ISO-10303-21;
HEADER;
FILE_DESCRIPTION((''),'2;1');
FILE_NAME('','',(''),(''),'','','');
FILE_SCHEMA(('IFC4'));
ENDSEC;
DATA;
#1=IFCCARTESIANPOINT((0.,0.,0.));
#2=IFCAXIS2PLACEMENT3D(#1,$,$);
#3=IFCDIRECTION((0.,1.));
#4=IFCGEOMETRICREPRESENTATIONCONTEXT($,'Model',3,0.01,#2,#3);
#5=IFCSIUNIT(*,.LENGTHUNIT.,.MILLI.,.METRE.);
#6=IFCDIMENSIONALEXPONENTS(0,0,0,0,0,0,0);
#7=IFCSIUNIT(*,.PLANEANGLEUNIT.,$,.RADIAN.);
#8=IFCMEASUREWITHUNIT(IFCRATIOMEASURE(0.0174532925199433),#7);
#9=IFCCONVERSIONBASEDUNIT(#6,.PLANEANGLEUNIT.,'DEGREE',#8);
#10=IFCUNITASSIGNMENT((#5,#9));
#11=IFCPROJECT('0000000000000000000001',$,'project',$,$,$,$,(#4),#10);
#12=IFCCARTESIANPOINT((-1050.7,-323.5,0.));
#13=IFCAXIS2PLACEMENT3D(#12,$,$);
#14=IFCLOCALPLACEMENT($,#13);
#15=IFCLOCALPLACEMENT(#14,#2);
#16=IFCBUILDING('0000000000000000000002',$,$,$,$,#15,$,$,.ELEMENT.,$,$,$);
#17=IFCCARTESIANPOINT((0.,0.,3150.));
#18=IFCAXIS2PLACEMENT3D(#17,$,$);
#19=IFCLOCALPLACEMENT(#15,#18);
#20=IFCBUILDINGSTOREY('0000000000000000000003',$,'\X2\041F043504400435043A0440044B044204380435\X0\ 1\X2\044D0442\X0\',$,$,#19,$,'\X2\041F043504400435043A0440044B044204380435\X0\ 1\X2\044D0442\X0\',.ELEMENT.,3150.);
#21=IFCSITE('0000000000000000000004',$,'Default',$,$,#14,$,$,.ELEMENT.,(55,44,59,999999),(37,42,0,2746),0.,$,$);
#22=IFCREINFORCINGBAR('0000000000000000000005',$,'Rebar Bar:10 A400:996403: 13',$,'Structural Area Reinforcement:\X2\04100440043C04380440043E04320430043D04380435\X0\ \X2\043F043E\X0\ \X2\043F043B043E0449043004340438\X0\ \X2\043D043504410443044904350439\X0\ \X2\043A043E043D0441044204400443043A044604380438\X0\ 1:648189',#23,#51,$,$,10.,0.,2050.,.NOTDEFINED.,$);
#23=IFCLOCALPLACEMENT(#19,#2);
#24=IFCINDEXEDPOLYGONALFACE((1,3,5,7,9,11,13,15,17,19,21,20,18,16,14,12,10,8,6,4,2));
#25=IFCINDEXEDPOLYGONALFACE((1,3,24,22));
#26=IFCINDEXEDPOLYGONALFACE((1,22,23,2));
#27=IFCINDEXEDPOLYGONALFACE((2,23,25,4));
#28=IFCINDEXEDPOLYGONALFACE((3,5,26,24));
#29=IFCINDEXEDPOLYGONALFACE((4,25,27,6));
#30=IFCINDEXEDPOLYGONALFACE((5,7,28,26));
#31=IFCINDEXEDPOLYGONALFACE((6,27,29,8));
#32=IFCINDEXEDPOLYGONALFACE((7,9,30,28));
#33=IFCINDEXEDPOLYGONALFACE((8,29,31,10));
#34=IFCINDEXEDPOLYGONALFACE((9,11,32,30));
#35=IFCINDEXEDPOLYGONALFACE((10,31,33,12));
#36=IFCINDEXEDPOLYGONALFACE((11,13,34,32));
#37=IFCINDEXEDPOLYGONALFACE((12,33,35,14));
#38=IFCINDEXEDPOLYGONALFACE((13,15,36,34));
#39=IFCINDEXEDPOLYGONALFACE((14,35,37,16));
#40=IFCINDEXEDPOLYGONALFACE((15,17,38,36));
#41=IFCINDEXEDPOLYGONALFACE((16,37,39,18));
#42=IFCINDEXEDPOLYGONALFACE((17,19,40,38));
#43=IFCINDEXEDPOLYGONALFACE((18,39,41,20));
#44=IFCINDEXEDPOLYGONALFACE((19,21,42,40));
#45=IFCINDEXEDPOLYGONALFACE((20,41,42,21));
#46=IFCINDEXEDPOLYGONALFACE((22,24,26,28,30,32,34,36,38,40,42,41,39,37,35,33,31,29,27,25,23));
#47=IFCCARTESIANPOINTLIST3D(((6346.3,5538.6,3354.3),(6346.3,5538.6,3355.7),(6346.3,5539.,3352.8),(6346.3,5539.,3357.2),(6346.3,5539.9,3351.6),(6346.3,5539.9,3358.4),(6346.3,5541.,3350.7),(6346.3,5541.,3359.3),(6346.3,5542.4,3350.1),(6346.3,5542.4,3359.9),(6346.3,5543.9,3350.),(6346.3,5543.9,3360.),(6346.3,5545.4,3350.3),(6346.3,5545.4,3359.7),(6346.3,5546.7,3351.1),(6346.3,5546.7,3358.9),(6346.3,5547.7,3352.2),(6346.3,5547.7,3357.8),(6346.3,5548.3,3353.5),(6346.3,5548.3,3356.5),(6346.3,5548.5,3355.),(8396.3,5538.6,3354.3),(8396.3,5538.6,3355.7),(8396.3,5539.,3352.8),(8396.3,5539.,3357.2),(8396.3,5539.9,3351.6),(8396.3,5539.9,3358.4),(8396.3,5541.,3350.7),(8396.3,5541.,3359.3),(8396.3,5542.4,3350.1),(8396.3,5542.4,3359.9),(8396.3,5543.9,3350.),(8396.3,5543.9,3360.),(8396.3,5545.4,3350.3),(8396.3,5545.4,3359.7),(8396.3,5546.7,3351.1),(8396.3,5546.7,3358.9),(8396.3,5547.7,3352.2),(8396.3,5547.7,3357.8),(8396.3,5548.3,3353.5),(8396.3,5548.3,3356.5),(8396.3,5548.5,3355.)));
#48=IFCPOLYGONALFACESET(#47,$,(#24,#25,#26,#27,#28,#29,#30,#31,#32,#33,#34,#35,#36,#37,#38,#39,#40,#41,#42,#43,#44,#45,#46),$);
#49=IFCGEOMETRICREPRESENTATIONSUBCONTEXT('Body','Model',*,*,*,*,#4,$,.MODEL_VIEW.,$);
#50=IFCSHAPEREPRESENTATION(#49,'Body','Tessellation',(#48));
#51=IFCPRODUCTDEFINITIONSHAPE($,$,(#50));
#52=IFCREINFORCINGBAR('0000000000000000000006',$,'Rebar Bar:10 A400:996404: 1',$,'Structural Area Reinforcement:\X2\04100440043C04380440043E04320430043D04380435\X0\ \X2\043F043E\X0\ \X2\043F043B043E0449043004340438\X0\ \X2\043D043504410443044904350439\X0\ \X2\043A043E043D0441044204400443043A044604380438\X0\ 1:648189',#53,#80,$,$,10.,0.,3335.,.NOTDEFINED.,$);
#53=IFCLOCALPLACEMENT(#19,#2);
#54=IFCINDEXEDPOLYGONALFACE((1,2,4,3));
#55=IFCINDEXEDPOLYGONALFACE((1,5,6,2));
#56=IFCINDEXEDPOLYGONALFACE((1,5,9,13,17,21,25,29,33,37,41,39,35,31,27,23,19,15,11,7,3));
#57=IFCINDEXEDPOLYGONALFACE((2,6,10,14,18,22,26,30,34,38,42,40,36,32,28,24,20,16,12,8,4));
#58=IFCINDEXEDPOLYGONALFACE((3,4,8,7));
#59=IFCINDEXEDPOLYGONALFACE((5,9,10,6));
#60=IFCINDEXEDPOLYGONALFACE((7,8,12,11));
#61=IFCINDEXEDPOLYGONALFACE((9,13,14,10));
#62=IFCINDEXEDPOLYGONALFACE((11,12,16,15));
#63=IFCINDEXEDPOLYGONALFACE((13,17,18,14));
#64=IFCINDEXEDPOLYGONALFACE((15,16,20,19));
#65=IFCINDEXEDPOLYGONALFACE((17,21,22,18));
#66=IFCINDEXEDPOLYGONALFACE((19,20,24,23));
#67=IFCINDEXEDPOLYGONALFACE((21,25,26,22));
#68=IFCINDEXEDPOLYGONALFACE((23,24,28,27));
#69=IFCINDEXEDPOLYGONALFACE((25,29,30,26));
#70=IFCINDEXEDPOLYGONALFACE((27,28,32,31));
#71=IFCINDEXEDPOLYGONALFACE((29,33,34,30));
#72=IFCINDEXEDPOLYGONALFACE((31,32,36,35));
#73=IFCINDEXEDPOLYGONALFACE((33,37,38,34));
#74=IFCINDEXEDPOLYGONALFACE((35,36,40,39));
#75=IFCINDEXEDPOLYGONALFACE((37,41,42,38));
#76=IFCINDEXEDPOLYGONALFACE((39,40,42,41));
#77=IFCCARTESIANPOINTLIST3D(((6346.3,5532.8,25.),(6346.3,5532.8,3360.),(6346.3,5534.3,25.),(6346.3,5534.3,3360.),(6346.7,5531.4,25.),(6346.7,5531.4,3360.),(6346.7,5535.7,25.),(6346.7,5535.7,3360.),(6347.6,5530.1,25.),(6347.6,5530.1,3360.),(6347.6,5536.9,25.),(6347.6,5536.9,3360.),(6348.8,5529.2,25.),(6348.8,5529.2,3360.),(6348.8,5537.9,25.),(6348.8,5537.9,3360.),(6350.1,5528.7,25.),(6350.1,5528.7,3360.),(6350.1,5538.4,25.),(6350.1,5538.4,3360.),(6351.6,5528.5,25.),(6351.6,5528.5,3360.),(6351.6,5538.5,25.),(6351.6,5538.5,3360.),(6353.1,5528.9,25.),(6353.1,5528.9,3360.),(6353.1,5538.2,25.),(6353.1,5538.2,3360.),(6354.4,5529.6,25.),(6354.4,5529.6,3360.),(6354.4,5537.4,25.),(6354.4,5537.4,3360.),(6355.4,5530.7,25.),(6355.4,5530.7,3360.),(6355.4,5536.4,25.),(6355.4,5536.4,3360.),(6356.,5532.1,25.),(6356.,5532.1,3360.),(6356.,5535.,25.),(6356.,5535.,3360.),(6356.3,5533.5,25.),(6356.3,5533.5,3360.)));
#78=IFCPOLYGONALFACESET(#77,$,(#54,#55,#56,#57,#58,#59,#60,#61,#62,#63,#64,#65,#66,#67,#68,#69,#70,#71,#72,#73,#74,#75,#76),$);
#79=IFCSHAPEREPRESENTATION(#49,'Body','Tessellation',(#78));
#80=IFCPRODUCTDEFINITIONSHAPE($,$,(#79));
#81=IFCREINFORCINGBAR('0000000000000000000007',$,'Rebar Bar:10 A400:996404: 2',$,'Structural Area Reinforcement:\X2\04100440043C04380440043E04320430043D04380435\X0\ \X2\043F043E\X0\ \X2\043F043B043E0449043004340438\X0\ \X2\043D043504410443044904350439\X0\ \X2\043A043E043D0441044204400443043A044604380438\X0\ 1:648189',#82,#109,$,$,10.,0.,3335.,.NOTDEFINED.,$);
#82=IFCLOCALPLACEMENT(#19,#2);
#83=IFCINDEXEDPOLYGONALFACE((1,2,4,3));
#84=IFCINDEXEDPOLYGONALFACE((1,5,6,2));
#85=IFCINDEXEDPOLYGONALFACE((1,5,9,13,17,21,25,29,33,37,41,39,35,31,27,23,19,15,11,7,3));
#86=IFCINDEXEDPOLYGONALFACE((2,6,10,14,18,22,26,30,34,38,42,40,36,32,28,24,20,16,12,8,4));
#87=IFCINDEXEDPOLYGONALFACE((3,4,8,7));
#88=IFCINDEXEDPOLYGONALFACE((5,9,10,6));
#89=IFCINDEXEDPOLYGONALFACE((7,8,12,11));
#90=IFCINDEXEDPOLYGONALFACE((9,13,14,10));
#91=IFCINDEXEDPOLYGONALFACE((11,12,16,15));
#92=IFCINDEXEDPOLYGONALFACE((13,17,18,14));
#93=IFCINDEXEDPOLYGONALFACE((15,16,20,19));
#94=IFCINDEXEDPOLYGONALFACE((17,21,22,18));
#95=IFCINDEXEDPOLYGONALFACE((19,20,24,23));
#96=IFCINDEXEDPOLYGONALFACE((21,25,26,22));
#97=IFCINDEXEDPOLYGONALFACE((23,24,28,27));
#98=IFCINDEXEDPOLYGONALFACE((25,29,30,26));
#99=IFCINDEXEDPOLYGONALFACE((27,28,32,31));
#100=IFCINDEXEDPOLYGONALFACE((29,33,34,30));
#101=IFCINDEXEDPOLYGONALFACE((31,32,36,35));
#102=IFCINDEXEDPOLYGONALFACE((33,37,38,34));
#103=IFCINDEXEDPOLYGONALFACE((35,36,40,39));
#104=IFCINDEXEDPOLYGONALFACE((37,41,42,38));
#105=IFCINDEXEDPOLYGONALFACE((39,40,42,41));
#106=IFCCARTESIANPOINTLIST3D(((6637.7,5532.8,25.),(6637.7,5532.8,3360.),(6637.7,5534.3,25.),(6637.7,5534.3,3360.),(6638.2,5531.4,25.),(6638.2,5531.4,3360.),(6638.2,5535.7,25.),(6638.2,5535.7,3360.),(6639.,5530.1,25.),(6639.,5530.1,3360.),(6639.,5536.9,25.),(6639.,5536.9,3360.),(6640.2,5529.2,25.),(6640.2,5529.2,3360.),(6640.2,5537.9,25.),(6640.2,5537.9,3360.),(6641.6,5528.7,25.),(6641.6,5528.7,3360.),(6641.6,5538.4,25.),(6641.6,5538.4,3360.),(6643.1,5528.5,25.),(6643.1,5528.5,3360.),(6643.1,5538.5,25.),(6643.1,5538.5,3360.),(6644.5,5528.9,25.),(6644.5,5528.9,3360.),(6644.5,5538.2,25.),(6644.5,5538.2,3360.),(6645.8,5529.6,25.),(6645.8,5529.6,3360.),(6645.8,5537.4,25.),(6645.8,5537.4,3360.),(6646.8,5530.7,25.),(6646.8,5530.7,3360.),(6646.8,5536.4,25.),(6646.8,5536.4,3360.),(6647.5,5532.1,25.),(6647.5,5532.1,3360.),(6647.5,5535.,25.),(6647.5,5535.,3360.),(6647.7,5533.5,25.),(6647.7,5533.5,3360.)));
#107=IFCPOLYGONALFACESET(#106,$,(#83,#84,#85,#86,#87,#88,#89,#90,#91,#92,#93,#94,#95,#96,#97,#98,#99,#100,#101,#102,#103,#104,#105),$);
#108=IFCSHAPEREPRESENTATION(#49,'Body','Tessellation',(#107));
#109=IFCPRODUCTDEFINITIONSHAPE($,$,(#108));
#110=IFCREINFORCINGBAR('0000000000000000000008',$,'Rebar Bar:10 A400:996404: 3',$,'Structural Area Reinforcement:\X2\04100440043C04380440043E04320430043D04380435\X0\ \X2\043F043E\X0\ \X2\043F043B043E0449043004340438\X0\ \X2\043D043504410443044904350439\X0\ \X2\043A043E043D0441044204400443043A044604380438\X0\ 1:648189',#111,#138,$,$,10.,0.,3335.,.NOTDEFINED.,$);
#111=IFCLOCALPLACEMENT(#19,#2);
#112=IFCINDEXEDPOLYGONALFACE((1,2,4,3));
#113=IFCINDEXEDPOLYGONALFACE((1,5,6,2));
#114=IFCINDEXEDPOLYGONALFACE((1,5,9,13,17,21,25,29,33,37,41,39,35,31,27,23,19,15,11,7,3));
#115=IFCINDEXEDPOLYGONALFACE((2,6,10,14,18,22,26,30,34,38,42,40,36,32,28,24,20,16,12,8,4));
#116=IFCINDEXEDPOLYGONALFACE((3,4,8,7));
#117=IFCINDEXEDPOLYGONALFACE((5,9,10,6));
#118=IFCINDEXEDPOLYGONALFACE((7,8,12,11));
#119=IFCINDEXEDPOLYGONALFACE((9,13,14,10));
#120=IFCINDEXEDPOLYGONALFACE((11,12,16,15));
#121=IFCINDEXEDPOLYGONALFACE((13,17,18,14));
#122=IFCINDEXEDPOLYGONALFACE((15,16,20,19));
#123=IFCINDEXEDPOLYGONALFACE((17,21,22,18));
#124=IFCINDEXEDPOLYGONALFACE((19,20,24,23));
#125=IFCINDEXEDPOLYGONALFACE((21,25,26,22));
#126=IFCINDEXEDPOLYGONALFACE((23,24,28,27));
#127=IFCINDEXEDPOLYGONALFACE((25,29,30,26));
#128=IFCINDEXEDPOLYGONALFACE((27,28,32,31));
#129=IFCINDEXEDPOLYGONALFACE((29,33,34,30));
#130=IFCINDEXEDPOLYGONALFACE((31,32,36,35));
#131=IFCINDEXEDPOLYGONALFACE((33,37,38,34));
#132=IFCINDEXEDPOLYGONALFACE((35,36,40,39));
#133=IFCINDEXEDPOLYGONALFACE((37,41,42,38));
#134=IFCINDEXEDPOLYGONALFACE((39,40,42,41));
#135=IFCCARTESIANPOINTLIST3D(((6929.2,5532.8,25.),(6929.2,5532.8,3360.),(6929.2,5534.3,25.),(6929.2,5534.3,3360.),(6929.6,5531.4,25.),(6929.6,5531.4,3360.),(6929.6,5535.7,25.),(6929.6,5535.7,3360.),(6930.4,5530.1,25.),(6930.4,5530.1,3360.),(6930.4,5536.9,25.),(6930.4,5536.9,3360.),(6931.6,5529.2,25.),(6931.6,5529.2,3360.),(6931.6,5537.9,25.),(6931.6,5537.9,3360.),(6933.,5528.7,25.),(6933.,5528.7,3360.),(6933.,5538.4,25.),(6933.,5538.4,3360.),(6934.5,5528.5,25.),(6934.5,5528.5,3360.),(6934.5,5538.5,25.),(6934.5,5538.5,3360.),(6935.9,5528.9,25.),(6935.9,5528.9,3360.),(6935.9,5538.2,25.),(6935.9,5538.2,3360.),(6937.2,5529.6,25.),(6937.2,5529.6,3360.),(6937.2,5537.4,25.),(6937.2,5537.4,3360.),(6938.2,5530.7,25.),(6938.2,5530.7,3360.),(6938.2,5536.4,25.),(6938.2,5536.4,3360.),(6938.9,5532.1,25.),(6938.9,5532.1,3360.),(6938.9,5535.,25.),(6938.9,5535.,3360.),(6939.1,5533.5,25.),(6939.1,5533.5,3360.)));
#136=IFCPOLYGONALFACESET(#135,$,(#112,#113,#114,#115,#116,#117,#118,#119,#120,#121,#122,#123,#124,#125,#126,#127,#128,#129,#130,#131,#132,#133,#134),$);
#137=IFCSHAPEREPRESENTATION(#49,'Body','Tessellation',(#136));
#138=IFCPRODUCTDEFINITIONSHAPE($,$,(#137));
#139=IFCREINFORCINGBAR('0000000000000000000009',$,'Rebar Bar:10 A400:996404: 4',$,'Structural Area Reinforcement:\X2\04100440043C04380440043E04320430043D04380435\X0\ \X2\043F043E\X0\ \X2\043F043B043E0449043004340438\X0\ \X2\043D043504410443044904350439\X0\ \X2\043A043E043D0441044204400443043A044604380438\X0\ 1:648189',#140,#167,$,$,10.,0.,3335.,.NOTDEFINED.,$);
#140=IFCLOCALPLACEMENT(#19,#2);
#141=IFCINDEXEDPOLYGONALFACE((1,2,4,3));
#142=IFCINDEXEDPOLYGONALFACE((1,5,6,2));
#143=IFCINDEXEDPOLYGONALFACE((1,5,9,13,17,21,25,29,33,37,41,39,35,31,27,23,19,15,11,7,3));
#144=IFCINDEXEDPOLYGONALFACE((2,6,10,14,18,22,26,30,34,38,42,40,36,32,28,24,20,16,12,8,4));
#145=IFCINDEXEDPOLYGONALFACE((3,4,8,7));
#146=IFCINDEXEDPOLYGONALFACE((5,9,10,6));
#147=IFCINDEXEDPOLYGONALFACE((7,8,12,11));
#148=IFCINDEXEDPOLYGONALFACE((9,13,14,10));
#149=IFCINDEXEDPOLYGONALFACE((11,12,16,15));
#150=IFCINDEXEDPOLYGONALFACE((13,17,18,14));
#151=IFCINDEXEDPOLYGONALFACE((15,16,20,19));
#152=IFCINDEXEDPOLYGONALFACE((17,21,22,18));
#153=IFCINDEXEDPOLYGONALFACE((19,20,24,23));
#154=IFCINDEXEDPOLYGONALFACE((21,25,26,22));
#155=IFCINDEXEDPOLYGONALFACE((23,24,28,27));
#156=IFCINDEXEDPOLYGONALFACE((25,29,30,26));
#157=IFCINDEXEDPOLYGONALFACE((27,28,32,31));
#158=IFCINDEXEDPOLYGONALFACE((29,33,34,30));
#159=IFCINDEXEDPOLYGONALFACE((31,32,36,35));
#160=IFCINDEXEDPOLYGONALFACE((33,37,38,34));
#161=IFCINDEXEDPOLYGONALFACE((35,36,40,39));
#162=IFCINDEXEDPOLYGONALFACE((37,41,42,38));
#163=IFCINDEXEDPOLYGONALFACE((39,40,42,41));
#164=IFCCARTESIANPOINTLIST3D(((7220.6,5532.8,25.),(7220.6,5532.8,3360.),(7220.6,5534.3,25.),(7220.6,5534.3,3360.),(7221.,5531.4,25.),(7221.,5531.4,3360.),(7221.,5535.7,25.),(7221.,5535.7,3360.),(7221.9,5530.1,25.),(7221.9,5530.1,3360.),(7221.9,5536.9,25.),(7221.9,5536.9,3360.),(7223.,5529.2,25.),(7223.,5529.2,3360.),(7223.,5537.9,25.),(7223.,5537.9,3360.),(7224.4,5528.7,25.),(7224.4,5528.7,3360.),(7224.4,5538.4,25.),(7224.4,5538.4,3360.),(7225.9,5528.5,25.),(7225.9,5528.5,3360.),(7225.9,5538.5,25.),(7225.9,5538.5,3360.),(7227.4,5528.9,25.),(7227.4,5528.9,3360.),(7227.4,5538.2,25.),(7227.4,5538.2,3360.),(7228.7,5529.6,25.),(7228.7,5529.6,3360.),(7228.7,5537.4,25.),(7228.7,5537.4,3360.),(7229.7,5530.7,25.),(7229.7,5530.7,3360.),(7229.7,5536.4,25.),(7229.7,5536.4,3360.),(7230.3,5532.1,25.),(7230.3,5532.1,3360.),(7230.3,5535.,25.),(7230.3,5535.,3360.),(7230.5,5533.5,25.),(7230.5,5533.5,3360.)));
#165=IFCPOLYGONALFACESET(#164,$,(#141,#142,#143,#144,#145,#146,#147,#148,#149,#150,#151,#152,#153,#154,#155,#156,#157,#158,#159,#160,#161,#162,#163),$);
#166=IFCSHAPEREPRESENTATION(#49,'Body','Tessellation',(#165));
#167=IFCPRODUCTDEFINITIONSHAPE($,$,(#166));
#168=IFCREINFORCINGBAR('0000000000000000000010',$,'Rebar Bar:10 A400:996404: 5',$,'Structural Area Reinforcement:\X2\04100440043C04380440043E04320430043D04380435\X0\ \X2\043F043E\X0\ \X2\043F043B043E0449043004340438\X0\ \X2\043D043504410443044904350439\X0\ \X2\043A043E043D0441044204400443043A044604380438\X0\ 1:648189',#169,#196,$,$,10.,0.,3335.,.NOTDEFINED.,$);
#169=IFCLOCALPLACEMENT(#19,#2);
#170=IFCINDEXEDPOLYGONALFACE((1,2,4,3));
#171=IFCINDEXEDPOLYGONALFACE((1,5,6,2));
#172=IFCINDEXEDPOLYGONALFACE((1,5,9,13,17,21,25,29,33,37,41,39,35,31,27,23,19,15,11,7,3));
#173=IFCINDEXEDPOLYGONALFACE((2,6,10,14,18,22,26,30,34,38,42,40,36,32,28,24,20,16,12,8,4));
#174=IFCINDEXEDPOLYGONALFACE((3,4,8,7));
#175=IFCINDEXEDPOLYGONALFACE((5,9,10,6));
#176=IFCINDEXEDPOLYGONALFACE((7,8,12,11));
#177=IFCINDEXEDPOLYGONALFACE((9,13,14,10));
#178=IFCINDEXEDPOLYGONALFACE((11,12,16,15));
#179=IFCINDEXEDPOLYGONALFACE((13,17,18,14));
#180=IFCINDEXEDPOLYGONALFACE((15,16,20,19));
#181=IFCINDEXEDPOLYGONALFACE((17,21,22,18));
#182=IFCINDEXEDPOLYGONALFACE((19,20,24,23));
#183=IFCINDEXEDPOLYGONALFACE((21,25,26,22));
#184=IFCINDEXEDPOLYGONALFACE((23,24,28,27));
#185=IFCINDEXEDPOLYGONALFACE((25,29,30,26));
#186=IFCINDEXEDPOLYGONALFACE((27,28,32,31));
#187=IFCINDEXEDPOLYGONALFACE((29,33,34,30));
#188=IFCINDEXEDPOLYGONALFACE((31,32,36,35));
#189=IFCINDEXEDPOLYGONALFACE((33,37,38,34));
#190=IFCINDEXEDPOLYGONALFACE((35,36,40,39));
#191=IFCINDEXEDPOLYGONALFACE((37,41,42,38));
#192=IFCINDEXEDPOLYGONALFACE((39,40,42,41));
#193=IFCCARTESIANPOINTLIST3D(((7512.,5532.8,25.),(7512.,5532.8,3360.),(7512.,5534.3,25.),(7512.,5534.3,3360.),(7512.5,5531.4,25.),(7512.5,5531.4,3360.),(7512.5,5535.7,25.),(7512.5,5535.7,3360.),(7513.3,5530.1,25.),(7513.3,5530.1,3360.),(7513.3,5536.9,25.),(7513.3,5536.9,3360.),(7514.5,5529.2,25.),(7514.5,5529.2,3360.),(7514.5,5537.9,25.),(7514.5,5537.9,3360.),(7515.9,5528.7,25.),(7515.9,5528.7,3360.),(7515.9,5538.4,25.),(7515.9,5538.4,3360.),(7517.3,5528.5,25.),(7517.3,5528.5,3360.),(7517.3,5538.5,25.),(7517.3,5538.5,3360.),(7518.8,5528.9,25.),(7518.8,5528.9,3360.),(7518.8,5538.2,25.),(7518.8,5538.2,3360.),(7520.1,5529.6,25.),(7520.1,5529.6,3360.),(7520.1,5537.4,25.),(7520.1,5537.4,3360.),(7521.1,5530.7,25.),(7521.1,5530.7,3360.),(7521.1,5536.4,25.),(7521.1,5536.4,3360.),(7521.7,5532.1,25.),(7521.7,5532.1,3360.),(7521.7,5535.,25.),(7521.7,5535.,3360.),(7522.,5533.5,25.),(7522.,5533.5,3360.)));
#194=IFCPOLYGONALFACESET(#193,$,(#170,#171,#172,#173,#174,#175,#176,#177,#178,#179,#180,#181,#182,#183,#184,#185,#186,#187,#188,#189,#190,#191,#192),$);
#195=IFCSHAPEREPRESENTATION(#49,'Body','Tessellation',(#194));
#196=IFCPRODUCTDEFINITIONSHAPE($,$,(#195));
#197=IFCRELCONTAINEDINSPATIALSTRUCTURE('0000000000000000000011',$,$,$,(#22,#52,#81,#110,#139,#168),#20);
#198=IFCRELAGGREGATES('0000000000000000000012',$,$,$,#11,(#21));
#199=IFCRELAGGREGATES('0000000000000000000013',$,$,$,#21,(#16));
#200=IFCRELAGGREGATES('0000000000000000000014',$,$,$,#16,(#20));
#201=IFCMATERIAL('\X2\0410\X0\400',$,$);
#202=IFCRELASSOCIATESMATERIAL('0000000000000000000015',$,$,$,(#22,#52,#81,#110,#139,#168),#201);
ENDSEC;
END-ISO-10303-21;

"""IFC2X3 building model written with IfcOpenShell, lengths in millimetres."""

from ifc_helpers import new_model, entity, si_unit, converted_unit, direction, frame, origin, place, context, subcontext, project, spatial, material, element, save


model = new_model("IFC2X3")

# Units and contexts
model_context = context("Model", 3, precision=0.01, world=origin(), true_north=direction((0.0, 1.0)))
body_context = subcontext(model_context, "Body", "Model", "MODEL_VIEW")
ifc_project = project(units=[si_unit("LENGTHUNIT", "METRE", prefix="MILLI"), converted_unit("PLANEANGLEUNIT", "DEGREE", entity("IfcRatioMeasure", 0.0174532925199433), si_unit("PLANEANGLEUNIT", "RADIAN"), dimensions=[0, 0, 0, 0, 0, 0, 0])], contexts=[model_context])

# Site, building, storey
site_placement = place(None, frame((-1050.7, -323.5, 0.0)))
site = spatial("IfcSite", under=ifc_project, at=site_placement, Name="Default", CompositionType="ELEMENT", RefLatitude=(55, 44, 59, 999999), RefLongitude=(37, 42, 0, 2746), RefElevation=0.0)
building_placement = place(site_placement, origin())
building = spatial("IfcBuilding", under=site, at=building_placement, CompositionType="ELEMENT")
storey_placement = place(building_placement, frame((0.0, 0.0, 3150.0)))
storey = spatial("IfcBuildingStorey", under=building, at=storey_placement, Name="Перекрытие 1эт", LongName="Перекрытие 1эт", CompositionType="ELEMENT", Elevation=3150.0)

# Reinforcing bars
ifc_material = material(Name="А400")
reinforcing_bar_1_placement = place(storey_placement, origin())
element("IfcReinforcingBar", 1, at=reinforcing_bar_1_placement, inside=storey, material=ifc_material, Name="Rebar Bar:10 A400:996403: 13", ObjectType="Structural Area Reinforcement:Армирование по площади несущей конструкции 1:648189", BarLength=2050.0, BarRole="NOTDEFINED", CrossSectionArea=0.0, NominalDiameter=10.0, context=body_context, shape_type="AdvancedSweptSolid", body=[
    entity("IfcSweptDiskSolid", entity("IfcCompositeCurve", [entity("IfcCompositeCurveSegment", "CONTINUOUS", True, entity("IfcPolyline", [entity("IfcCartesianPoint", [6346.3, 5543.5, 3355.0]), entity("IfcCartesianPoint", [8396.3, 5543.5, 3355.0])]))], False), 5.0, None, 0.0, 1.0),
])
reinforcing_bar_2_placement = place(storey_placement, origin())
element("IfcReinforcingBar", 2, at=reinforcing_bar_2_placement, inside=storey, material=ifc_material, Name="Rebar Bar:10 A400:996404: 1", ObjectType="Structural Area Reinforcement:Армирование по площади несущей конструкции 1:648189", BarLength=3335.0, BarRole="NOTDEFINED", CrossSectionArea=0.0, NominalDiameter=10.0, context=body_context, shape_type="AdvancedSweptSolid", body=[
    entity("IfcSweptDiskSolid", entity("IfcCompositeCurve", [entity("IfcCompositeCurveSegment", "CONTINUOUS", True, entity("IfcPolyline", [entity("IfcCartesianPoint", [6351.3, 5533.5, 25.0]), entity("IfcCartesianPoint", [6351.3, 5533.5, 3360.0])]))], False), 5.0, None, 0.0, 1.0),
])
reinforcing_bar_3_placement = place(storey_placement, origin())
element("IfcReinforcingBar", 3, at=reinforcing_bar_3_placement, inside=storey, material=ifc_material, Name="Rebar Bar:10 A400:996404: 2", ObjectType="Structural Area Reinforcement:Армирование по площади несущей конструкции 1:648189", BarLength=3335.0, BarRole="NOTDEFINED", CrossSectionArea=0.0, NominalDiameter=10.0, context=body_context, shape_type="AdvancedSweptSolid", body=[
    entity("IfcSweptDiskSolid", entity("IfcCompositeCurve", [entity("IfcCompositeCurveSegment", "CONTINUOUS", True, entity("IfcPolyline", [entity("IfcCartesianPoint", [6642.7, 5533.5, 25.0]), entity("IfcCartesianPoint", [6642.7, 5533.5, 3360.0])]))], False), 5.0, None, 0.0, 1.0),
])
reinforcing_bar_4_placement = place(storey_placement, origin())
element("IfcReinforcingBar", 4, at=reinforcing_bar_4_placement, inside=storey, material=ifc_material, Name="Rebar Bar:10 A400:996404: 3", ObjectType="Structural Area Reinforcement:Армирование по площади несущей конструкции 1:648189", BarLength=3335.0, BarRole="NOTDEFINED", CrossSectionArea=0.0, NominalDiameter=10.0, context=body_context, shape_type="AdvancedSweptSolid", body=[
    entity("IfcSweptDiskSolid", entity("IfcCompositeCurve", [entity("IfcCompositeCurveSegment", "CONTINUOUS", True, entity("IfcPolyline", [entity("IfcCartesianPoint", [6934.1, 5533.5, 25.0]), entity("IfcCartesianPoint", [6934.1, 5533.5, 3360.0])]))], False), 5.0, None, 0.0, 1.0),
])
reinforcing_bar_5_placement = place(storey_placement, origin())
element("IfcReinforcingBar", 5, at=reinforcing_bar_5_placement, inside=storey, material=ifc_material, Name="Rebar Bar:10 A400:996404: 4", ObjectType="Structural Area Reinforcement:Армирование по площади несущей конструкции 1:648189", BarLength=3335.0, BarRole="NOTDEFINED", CrossSectionArea=0.0, NominalDiameter=10.0, context=body_context, shape_type="AdvancedSweptSolid", body=[
    entity("IfcSweptDiskSolid", entity("IfcCompositeCurve", [entity("IfcCompositeCurveSegment", "CONTINUOUS", True, entity("IfcPolyline", [entity("IfcCartesianPoint", [7225.5, 5533.5, 25.0]), entity("IfcCartesianPoint", [7225.5, 5533.5, 3360.0])]))], False), 5.0, None, 0.0, 1.0),
])
reinforcing_bar_6_placement = place(storey_placement, origin())
element("IfcReinforcingBar", 6, at=reinforcing_bar_6_placement, inside=storey, material=ifc_material, Name="Rebar Bar:10 A400:996404: 5", ObjectType="Structural Area Reinforcement:Армирование по площади несущей конструкции 1:648189", BarLength=3335.0, BarRole="NOTDEFINED", CrossSectionArea=0.0, NominalDiameter=10.0, context=body_context, shape_type="AdvancedSweptSolid", body=[
    entity("IfcSweptDiskSolid", entity("IfcCompositeCurve", [entity("IfcCompositeCurveSegment", "CONTINUOUS", True, entity("IfcPolyline", [entity("IfcCartesianPoint", [7517.0, 5533.5, 25.0]), entity("IfcCartesianPoint", [7517.0, 5533.5, 3360.0])]))], False), 5.0, None, 0.0, 1.0),
])

save(model, "model.ifc")
